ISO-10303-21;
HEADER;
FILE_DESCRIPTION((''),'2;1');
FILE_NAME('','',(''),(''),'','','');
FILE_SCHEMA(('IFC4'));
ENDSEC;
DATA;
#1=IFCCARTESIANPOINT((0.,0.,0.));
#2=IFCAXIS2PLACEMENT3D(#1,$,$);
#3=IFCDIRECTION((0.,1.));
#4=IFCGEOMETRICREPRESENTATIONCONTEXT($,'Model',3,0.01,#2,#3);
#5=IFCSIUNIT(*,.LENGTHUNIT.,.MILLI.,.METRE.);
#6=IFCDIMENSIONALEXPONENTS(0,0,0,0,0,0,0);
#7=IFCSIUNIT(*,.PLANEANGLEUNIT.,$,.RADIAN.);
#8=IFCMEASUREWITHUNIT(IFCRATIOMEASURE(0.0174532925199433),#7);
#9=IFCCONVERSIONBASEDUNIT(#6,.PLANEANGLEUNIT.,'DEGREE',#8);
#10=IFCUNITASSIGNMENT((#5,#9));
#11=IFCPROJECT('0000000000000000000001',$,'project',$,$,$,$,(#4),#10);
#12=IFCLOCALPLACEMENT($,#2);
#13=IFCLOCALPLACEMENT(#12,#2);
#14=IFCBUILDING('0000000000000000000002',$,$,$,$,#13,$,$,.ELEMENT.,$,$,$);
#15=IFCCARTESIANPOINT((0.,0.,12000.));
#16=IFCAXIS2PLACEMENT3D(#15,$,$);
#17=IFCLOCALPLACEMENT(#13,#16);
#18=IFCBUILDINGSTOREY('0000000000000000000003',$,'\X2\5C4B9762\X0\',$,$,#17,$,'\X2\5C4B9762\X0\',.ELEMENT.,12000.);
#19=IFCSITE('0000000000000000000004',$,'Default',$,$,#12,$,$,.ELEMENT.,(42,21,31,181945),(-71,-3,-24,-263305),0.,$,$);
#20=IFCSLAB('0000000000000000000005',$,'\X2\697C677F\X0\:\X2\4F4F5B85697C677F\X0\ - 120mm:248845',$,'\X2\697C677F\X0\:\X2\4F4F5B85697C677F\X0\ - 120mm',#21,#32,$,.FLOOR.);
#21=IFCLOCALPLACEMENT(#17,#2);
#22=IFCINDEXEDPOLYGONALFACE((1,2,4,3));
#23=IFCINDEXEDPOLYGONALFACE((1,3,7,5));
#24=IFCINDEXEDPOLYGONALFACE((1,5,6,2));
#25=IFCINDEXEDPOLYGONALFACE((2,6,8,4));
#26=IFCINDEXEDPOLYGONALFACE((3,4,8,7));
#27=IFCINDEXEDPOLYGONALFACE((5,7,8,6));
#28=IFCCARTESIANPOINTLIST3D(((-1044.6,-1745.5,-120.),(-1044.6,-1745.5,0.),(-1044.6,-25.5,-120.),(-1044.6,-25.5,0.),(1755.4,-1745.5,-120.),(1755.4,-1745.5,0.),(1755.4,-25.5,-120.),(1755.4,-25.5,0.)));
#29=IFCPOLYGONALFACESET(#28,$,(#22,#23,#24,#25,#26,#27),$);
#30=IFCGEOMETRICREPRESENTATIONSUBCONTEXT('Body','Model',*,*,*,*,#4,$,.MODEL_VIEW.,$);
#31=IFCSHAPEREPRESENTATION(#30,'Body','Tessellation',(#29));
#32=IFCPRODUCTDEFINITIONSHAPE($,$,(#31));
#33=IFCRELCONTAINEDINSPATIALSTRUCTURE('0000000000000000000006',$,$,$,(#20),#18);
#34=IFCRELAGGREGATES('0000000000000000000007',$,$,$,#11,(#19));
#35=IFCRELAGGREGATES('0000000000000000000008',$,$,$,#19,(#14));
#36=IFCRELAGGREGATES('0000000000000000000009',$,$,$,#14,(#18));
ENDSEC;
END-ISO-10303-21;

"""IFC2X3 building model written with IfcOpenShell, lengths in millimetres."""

from ifc_helpers import new_model, entity, si_unit, converted_unit, direction, frame, origin, origin_2d_with_axis, place, context, subcontext, project, spatial, rectangle, extrude, element, save


model = new_model("IFC2X3")

# Units and contexts
model_context = context("Model", 3, precision=0.01, world=origin(), true_north=direction((0.0, 1.0)))
body_context = subcontext(model_context, "Body", "Model", "MODEL_VIEW")
ifc_project = project(units=[si_unit("LENGTHUNIT", "METRE", prefix="MILLI"), converted_unit("PLANEANGLEUNIT", "DEGREE", entity("IfcRatioMeasure", 0.0174532925199433), si_unit("PLANEANGLEUNIT", "RADIAN"), dimensions=[0, 0, 0, 0, 0, 0, 0])], contexts=[model_context])

# Site, building, storey
site_placement = place(None, origin())
site = spatial("IfcSite", under=ifc_project, at=site_placement, Name="Default", CompositionType="ELEMENT", RefLatitude=(42, 21, 31, 181945), RefLongitude=(-71, -3, -24, -263305), RefElevation=0.0)
building_placement = place(site_placement, origin())
building = spatial("IfcBuilding", under=site, at=building_placement, CompositionType="ELEMENT")
storey_placement = place(building_placement, frame((0.0, 0.0, 12000.0)))
storey = spatial("IfcBuildingStorey", under=building, at=storey_placement, Name="屋面", LongName="屋面", CompositionType="ELEMENT", Elevation=12000.0)

# Slab
slab_1_placement = place(storey_placement, origin())
element("IfcSlab", 1, at=slab_1_placement, inside=storey, Name="楼板:住宅楼板 - 120mm:248845", ObjectType="楼板:住宅楼板 - 120mm", PredefinedType="FLOOR", context=body_context, shape_type="SweptSolid", body=[
    extrude(rectangle(XDim=1720.0, YDim=2800.0, at=origin_2d_with_axis()), frame((355.4, -885.5, 0.0), z_axis=(0.0, 0.0, -1.0), x_axis=(0.0, 1.0, 0.0)), (0.0, 0.0, 1.0), 120.0),
])

save(model, "model.ifc")
